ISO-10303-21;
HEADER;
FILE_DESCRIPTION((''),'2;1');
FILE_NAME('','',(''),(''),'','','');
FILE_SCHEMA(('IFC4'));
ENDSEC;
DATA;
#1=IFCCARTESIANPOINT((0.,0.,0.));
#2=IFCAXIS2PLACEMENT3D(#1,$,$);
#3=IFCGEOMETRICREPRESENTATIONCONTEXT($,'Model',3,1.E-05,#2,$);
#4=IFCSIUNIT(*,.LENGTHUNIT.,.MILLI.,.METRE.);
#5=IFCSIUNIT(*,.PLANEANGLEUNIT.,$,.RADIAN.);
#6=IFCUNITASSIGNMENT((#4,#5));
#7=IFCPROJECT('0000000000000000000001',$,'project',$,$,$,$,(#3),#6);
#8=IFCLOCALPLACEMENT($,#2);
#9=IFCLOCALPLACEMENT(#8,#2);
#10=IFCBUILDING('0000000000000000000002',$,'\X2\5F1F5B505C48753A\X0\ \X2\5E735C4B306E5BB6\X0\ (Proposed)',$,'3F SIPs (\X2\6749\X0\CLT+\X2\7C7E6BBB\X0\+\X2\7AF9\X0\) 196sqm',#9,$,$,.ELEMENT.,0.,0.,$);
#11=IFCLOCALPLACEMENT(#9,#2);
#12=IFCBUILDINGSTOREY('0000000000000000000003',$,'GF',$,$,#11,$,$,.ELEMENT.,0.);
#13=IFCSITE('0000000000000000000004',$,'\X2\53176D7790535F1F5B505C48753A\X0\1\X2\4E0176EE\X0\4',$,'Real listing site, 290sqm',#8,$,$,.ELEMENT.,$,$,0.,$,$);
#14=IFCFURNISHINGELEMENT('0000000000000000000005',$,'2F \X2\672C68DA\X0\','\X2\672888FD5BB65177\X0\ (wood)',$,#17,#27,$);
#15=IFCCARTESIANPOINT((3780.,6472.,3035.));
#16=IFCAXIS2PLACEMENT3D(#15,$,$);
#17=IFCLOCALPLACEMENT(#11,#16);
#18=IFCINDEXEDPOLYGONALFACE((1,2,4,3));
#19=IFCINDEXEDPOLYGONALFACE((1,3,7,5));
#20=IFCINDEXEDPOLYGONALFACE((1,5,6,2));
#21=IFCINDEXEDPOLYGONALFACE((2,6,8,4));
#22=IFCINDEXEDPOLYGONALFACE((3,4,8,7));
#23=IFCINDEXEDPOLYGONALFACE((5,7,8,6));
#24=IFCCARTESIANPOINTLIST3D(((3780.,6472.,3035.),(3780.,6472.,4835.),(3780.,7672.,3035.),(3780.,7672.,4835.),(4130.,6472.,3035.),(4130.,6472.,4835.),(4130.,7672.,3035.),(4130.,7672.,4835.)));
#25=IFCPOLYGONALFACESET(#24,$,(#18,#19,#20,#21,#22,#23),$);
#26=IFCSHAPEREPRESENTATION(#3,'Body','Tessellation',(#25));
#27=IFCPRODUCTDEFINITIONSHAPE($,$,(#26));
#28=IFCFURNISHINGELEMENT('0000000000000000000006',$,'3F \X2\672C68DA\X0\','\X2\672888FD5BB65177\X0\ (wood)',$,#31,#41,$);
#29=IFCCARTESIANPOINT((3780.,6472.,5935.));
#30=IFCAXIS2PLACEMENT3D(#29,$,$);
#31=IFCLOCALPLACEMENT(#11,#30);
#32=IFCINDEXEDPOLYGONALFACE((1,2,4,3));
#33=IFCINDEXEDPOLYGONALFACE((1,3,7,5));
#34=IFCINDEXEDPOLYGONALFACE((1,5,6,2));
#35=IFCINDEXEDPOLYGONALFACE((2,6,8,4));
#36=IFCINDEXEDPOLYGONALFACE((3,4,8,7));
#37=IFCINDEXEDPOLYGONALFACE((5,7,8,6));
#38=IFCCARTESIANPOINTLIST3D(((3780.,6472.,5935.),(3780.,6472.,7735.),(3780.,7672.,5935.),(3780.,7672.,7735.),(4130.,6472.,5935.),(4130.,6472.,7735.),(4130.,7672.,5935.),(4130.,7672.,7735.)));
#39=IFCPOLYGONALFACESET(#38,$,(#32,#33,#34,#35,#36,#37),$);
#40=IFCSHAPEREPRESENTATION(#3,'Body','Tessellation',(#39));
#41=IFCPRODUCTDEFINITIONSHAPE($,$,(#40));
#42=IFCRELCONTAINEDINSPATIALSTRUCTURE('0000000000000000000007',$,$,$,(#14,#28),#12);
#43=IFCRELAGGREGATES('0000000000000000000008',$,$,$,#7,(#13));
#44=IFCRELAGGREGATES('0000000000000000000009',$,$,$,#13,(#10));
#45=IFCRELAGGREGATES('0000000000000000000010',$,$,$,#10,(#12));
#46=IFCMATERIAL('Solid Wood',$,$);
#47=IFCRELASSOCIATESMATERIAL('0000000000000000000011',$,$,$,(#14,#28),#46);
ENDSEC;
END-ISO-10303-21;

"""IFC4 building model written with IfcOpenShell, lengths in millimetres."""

from ifc_helpers import new_model, si_unit, frame, frame_2d, origin, place, context, project, spatial, rectangle, extrude, material, element, save


model = new_model("IFC4")

# Units and contexts
model_context = context("Model", 3, precision=1e-05, world=origin())
ifc_project = project(units=[si_unit("LENGTHUNIT", "METRE", prefix="MILLI"), si_unit("PLANEANGLEUNIT", "RADIAN")], contexts=[model_context])

# Site, building, storey
site_placement = place(None, origin())
site = spatial("IfcSite", under=ifc_project, at=site_placement, Name="北海道弟子屈町1丁目4", ObjectType="Real listing site, 290sqm", CompositionType="ELEMENT", RefElevation=0.0)
building_placement = place(site_placement, origin())
building = spatial("IfcBuilding", under=site, at=building_placement, Name="弟子屈町 平屋の家 (Proposed)", ObjectType="3F SIPs (杉CLT+籾殻+竹) 196sqm", CompositionType="ELEMENT", ElevationOfRefHeight=0.0, ElevationOfTerrain=0.0)
storey_placement = place(building_placement, origin())
storey = spatial("IfcBuildingStorey", under=building, at=storey_placement, Name="GF", CompositionType="ELEMENT", Elevation=0.0)

# Shared definitions
ifc_material_1 = material(Name="Solid Wood")

# Furnishing elements
furnishing_1_placement = place(storey_placement, frame((3780.0, 6472.0, 3035.0)))
element("IfcFurnishingElement", 1, at=furnishing_1_placement, inside=storey, material=ifc_material_1, Name="2F 本棚", Description="木製家具 (wood)", context=model_context, shape_type="SweptSolid", body=[
    extrude(rectangle(XDim=350.0, YDim=1200.0, at=frame_2d((175.0, 600.0))), frame((3780.0, 6472.0, 3035.0)), (0.0, 0.0, 1.0), 1800.0),
])
furnishing_2_placement = place(storey_placement, frame((3780.0, 6472.0, 5935.0)))
element("IfcFurnishingElement", 2, at=furnishing_2_placement, inside=storey, material=ifc_material_1, Name="3F 本棚", Description="木製家具 (wood)", context=model_context, shape_type="SweptSolid", body=[
    extrude(rectangle(XDim=350.0, YDim=1200.0, at=frame_2d((175.0, 600.0))), frame((3780.0, 6472.0, 5935.0)), (0.0, 0.0, 1.0), 1800.0),
])

save(model, "model.ifc")
